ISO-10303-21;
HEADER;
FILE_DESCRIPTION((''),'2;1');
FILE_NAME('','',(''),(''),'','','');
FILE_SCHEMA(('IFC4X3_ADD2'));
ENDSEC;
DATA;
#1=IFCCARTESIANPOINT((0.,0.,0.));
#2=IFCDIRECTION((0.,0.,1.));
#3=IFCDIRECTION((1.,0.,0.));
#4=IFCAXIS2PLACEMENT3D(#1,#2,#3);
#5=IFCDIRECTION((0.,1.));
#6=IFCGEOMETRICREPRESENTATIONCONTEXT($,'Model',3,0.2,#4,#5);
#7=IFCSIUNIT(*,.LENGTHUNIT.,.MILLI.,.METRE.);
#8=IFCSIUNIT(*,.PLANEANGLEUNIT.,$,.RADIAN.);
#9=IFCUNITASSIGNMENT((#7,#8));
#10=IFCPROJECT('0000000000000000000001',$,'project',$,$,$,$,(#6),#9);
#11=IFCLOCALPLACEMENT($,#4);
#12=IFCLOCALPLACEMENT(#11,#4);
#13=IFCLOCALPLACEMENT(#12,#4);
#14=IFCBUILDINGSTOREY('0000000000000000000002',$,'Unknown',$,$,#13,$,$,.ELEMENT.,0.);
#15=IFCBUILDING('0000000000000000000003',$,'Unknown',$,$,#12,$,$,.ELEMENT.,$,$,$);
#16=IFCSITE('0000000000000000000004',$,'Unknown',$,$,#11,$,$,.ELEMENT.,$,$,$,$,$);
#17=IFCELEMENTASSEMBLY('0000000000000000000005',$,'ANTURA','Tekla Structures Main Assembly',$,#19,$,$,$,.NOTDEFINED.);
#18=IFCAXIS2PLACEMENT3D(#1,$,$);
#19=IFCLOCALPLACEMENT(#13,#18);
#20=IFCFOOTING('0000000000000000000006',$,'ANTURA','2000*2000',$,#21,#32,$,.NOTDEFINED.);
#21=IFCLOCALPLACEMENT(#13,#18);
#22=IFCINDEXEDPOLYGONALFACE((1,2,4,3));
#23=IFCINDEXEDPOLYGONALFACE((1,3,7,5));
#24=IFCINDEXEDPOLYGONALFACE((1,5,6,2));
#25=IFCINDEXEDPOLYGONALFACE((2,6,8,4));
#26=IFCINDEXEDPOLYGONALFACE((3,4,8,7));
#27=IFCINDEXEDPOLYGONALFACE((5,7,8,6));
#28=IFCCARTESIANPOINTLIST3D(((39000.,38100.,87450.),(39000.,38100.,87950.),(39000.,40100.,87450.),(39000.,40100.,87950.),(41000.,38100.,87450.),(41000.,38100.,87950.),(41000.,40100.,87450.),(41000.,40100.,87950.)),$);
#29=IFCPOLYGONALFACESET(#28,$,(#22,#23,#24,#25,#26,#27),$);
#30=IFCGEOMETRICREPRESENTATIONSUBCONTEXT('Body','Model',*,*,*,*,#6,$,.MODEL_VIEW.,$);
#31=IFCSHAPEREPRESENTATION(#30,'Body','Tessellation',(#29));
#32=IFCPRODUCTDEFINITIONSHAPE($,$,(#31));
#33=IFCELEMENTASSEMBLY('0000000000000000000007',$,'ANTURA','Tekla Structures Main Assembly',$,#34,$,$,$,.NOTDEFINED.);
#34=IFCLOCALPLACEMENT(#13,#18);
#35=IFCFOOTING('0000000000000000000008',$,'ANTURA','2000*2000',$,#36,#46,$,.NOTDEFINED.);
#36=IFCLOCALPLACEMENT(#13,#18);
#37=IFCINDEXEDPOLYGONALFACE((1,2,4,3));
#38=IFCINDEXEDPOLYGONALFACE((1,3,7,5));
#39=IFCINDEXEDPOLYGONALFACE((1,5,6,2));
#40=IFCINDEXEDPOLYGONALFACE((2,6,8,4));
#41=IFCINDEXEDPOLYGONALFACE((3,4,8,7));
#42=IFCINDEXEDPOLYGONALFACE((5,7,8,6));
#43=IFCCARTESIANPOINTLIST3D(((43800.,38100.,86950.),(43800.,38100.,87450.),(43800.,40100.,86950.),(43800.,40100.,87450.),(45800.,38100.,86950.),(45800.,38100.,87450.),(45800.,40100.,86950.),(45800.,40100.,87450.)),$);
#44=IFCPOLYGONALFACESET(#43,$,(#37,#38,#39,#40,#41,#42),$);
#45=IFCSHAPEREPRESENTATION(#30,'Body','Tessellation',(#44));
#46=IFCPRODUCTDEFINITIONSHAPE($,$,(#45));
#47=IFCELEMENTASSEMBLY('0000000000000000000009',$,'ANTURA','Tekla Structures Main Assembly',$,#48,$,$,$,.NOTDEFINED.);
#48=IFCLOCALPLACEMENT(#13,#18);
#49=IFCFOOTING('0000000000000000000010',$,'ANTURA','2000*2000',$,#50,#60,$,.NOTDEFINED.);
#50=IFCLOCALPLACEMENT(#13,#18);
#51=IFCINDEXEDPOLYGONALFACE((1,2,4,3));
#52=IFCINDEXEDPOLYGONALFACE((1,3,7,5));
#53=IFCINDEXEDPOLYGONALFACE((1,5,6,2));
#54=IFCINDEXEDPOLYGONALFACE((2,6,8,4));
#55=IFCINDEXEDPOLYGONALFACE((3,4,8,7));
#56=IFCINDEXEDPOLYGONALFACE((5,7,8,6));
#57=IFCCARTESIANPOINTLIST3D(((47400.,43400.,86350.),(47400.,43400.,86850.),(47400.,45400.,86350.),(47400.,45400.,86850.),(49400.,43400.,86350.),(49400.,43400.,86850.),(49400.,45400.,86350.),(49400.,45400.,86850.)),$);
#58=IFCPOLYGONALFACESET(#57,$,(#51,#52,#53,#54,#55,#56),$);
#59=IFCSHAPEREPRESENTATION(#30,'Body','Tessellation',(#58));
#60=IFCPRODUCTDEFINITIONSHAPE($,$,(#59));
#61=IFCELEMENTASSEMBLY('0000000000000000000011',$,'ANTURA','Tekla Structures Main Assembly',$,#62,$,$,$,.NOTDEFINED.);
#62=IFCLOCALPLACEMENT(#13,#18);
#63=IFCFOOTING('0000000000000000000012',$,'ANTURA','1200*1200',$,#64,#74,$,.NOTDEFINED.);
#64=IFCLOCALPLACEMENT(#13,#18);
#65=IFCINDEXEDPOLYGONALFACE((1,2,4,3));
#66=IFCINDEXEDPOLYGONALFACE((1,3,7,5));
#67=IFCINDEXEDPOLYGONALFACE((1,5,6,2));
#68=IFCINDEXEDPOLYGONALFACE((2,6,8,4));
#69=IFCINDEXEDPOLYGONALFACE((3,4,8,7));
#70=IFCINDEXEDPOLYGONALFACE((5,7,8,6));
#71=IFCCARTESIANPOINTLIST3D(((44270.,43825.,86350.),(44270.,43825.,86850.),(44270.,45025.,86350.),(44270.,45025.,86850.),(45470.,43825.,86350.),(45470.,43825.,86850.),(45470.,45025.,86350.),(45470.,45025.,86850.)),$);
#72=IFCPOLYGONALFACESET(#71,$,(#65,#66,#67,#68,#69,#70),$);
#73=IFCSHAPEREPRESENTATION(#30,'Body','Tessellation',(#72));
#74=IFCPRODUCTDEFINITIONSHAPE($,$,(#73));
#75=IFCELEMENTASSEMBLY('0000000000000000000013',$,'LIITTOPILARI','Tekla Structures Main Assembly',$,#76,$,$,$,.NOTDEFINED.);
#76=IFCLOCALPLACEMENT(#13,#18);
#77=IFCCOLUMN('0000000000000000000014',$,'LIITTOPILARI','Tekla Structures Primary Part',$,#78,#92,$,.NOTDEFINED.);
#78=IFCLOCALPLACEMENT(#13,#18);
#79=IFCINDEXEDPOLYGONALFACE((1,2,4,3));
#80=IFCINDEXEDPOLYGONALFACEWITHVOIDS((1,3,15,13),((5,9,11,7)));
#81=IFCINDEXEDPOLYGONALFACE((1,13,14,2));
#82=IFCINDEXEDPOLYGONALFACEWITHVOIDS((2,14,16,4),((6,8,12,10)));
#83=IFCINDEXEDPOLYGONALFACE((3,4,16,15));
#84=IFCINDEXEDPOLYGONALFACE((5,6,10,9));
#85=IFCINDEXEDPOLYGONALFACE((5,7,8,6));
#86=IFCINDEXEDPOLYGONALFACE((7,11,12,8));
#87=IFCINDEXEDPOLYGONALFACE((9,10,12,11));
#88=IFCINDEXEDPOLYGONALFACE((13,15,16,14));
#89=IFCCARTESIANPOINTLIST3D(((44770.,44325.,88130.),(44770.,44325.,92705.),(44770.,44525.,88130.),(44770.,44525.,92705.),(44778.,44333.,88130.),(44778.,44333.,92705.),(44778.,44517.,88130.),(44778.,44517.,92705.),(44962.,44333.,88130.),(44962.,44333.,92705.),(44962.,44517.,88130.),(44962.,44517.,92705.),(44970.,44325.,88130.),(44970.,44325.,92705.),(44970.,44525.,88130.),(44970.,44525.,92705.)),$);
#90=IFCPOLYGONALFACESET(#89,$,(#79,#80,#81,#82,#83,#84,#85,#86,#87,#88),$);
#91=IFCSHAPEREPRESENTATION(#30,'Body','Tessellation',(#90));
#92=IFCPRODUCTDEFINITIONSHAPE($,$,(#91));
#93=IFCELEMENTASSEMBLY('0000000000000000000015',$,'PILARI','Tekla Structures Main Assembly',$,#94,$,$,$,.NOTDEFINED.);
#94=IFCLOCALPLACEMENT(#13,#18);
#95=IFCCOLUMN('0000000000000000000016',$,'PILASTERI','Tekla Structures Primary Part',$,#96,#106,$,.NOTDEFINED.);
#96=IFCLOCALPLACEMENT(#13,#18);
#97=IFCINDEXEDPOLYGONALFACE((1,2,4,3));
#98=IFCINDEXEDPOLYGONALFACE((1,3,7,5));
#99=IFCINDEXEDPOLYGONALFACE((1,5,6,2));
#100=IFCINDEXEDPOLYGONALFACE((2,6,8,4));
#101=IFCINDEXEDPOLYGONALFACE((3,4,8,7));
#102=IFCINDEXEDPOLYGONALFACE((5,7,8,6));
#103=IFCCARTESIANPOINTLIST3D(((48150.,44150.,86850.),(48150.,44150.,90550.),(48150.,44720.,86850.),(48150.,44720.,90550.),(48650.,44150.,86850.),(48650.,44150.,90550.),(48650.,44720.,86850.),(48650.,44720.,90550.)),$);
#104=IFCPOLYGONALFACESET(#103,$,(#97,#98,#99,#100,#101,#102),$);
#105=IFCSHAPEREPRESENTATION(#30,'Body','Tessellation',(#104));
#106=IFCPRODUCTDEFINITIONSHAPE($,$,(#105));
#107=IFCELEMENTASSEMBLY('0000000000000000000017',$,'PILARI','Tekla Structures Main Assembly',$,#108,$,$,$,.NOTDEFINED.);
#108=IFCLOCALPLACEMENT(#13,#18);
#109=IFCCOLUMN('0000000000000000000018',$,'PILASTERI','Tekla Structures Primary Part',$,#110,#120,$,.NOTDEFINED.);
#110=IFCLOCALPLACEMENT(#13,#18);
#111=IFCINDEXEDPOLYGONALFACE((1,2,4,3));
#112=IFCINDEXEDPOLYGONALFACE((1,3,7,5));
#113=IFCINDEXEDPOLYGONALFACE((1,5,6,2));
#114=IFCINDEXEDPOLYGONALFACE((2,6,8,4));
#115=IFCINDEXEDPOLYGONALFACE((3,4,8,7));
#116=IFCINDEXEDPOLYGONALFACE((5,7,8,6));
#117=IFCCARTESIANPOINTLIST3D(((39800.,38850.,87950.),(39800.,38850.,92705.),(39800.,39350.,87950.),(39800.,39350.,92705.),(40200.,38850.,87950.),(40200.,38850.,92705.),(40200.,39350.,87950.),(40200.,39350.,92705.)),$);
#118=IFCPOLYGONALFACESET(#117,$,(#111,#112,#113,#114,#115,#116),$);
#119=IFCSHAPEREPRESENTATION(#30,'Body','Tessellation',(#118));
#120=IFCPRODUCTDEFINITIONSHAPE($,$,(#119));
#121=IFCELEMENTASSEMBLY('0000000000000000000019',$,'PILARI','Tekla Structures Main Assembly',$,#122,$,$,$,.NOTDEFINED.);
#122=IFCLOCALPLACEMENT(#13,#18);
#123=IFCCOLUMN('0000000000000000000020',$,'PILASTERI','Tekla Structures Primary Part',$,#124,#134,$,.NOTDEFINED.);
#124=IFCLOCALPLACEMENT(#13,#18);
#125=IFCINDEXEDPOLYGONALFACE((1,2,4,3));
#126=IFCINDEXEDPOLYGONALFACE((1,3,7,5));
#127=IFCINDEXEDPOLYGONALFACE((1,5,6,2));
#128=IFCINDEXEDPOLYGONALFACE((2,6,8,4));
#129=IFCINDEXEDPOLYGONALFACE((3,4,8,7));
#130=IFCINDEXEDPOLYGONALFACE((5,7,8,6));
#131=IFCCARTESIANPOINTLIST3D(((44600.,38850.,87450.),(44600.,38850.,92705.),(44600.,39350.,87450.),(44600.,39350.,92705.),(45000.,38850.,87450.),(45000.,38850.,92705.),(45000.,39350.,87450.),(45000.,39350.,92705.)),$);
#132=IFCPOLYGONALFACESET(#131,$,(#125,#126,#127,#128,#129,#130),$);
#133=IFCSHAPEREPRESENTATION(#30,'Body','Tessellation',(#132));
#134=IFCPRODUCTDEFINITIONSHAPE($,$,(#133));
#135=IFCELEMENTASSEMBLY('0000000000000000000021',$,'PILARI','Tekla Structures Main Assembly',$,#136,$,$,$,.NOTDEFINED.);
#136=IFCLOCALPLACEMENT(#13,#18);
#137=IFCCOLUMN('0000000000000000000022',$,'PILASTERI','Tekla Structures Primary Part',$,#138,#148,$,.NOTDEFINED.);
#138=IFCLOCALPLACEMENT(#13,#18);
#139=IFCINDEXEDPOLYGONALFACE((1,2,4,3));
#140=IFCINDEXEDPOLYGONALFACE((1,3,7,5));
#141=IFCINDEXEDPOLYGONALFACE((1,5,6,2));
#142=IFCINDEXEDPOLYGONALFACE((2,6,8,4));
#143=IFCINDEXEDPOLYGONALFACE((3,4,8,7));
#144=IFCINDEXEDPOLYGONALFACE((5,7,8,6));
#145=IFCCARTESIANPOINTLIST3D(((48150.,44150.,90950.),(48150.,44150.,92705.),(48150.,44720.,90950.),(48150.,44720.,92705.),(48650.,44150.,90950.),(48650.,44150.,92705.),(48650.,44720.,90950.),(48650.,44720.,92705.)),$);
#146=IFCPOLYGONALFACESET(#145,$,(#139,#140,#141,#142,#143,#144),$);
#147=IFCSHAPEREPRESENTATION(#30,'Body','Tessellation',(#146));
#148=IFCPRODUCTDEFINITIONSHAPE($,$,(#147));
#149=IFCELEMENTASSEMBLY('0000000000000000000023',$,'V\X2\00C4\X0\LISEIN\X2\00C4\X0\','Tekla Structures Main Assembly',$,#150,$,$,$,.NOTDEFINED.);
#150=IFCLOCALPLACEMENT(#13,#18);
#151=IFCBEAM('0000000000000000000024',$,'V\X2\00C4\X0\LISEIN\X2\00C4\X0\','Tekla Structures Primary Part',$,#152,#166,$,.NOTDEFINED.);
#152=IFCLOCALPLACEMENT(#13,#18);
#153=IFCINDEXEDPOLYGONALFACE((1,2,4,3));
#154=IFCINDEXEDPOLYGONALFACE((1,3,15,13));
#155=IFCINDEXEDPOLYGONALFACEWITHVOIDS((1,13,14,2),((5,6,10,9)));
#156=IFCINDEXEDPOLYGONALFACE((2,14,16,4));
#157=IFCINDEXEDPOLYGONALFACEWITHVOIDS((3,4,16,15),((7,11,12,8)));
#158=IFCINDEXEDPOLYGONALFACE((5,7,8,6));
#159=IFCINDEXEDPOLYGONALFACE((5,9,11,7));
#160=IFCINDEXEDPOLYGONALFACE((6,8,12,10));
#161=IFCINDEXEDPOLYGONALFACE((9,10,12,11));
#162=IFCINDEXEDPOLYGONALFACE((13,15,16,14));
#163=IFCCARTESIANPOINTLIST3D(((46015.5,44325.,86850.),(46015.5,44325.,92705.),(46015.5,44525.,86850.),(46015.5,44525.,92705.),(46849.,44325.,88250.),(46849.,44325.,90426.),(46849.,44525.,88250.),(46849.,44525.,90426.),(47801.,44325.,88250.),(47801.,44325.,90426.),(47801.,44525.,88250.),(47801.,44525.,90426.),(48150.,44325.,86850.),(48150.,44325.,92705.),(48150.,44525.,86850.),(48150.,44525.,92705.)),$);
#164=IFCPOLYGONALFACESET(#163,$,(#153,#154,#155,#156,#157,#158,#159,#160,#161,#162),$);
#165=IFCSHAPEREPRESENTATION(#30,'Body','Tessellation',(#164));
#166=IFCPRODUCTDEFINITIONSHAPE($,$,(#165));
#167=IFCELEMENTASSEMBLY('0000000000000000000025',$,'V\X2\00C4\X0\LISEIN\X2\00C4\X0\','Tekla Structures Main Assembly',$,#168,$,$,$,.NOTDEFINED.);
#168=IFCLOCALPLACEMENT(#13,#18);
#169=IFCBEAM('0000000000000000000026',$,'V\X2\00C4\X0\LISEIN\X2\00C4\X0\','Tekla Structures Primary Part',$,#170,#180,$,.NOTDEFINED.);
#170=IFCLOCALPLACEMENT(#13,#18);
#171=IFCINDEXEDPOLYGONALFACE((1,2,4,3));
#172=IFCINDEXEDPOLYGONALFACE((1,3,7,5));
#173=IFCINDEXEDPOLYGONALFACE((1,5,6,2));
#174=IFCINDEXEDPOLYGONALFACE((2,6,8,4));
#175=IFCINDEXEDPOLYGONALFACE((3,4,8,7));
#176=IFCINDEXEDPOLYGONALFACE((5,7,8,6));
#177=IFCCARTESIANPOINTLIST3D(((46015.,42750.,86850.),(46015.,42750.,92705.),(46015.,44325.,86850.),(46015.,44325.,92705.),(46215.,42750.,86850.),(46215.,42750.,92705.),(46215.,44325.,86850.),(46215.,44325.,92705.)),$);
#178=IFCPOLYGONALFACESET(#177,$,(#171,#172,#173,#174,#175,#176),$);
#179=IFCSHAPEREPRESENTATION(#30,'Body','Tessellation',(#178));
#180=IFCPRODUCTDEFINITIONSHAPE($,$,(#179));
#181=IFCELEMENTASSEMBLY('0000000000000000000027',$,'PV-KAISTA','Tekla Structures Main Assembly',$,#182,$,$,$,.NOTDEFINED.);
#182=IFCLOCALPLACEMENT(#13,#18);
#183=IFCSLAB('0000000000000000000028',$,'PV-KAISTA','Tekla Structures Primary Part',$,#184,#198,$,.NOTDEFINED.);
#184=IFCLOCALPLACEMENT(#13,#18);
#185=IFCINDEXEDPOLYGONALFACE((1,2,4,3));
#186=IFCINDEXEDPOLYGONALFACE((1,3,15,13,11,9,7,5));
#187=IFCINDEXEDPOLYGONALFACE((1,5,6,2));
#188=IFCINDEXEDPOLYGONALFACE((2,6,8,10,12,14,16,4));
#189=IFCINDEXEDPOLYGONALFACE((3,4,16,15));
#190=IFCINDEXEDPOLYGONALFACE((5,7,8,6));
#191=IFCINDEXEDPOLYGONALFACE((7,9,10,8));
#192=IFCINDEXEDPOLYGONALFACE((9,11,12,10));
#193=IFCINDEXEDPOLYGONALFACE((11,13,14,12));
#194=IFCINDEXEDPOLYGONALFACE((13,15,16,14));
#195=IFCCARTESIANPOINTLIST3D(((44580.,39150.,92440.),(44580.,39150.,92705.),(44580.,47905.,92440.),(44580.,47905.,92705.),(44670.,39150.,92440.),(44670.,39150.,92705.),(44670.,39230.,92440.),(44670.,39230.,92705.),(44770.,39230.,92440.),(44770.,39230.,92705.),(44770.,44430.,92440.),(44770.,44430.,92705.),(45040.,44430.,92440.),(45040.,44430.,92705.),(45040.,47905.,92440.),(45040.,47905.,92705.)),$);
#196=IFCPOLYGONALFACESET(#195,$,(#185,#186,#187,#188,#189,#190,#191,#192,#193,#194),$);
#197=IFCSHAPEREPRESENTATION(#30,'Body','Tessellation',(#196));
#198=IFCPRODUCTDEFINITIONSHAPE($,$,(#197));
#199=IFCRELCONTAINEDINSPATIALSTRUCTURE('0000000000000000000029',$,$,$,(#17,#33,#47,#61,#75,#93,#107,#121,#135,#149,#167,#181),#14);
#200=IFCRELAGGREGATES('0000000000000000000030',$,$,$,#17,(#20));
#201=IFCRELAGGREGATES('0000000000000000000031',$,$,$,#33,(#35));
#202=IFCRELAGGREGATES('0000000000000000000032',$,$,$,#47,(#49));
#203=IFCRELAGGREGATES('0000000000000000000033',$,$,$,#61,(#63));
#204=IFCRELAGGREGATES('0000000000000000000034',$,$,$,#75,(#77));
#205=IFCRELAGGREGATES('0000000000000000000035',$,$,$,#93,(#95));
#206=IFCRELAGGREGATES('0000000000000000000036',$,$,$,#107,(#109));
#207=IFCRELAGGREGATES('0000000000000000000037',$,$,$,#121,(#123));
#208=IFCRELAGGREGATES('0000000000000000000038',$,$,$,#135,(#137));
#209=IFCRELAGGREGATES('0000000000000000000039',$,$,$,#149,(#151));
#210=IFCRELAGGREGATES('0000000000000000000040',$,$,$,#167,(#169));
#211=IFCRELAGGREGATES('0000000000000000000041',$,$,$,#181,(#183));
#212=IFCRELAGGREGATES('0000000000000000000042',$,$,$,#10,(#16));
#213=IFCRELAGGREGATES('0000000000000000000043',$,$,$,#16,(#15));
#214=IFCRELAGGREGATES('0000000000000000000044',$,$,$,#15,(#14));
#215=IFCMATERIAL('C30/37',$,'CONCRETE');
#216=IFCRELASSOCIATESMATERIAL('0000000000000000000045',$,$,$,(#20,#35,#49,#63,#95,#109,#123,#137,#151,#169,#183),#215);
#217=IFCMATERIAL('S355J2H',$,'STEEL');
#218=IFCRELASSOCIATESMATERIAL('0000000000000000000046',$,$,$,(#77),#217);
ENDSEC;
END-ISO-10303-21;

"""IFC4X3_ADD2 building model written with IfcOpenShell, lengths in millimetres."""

from ifc_helpers import new_model, si_unit, direction, frame, origin_with_axes, place, context, subcontext, project, spatial, line, indexed_curve, outline, extrude, material, element, aggregate, save


model = new_model("IFC4X3_ADD2")

# Units and contexts
model_context = context("Model", 3, precision=0.2, world=origin_with_axes(), true_north=direction((0.0, 1.0)))
body_context = subcontext(model_context, "Body", "Model", "MODEL_VIEW")
ifc_project = project(units=[si_unit("LENGTHUNIT", "METRE", prefix="MILLI"), si_unit("PLANEANGLEUNIT", "RADIAN")], contexts=[model_context])

# Site, building, storey
site_placement = place(None, origin_with_axes())
site = spatial("IfcSite", under=ifc_project, at=site_placement, Name="Unknown", CompositionType="ELEMENT")
building_placement = place(site_placement, origin_with_axes())
building = spatial("IfcBuilding", under=site, at=building_placement, Name="Unknown", CompositionType="ELEMENT")
storey_placement = place(building_placement, origin_with_axes())
storey = spatial("IfcBuildingStorey", under=building, at=storey_placement, Name="Unknown", CompositionType="ELEMENT", Elevation=0.0)

# Element assemblies, footings
assembly_1_placement = place(storey_placement, frame((40000.0, 39100.0, 87450.0), z_axis=(-1.0, 0.0, 0.0), x_axis=(0.0, 0.0, 1.0)))
assembly_1 = element("IfcElementAssembly", 1, at=assembly_1_placement, inside=storey, Name="ANTURA", Description="Tekla Structures Main Assembly", PredefinedType="NOTDEFINED")
ifc_material_1 = material(Name="C30/37", Category="CONCRETE")
footing_1_placement = place(assembly_1_placement, origin_with_axes())
footing_1 = element("IfcFooting", 2, at=footing_1_placement, material=ifc_material_1, Name="ANTURA", Description="2000*2000", PredefinedType="NOTDEFINED", context=body_context, shape_type="SolidModel", body=[
    extrude(outline(indexed_curve([(-1000.0, -1000.0), (1000.0, -1000.0), (1000.0, 1000.0), (-1000.0, 1000.0)], segments=[line(1, 2, 3, 4, 1)])), frame((0.0, 0.0, 0.0), z_axis=(-1.0, 0.0, 0.0), x_axis=(0.0, 0.0, 1.0)), (0.0, 0.0, -1.0), 500.0),
])
aggregate(assembly_1, [footing_1])
assembly_2_placement = place(storey_placement, frame((44800.0, 39100.0, 86950.0), z_axis=(-1.0, 0.0, 0.0), x_axis=(0.0, 0.0, 1.0)))
assembly_2 = element("IfcElementAssembly", 3, at=assembly_2_placement, inside=storey, Name="ANTURA", Description="Tekla Structures Main Assembly", PredefinedType="NOTDEFINED")
footing_2_placement = place(assembly_2_placement, origin_with_axes())
footing_2 = element("IfcFooting", 4, at=footing_2_placement, material=ifc_material_1, Name="ANTURA", Description="2000*2000", PredefinedType="NOTDEFINED", context=body_context, shape_type="SolidModel", body=[
    extrude(outline(indexed_curve([(-1000.0, -1000.0), (1000.0, -1000.0), (1000.0, 1000.0), (-1000.0, 1000.0)], segments=[line(1, 2, 3, 4, 1)])), frame((0.0, 0.0, 0.0), z_axis=(-1.0, 0.0, 0.0), x_axis=(0.0, 0.0, 1.0)), (0.0, 0.0, -1.0), 500.0),
])
aggregate(assembly_2, [footing_2])
assembly_3_placement = place(storey_placement, frame((48400.0, 44400.0, 86350.0), z_axis=(-1.0, 0.0, 0.0), x_axis=(0.0, 0.0, 1.0)))
assembly_3 = element("IfcElementAssembly", 5, at=assembly_3_placement, inside=storey, Name="ANTURA", Description="Tekla Structures Main Assembly", PredefinedType="NOTDEFINED")
footing_3_placement = place(assembly_3_placement, origin_with_axes())
footing_3 = element("IfcFooting", 6, at=footing_3_placement, material=ifc_material_1, Name="ANTURA", Description="2000*2000", PredefinedType="NOTDEFINED", context=body_context, shape_type="SolidModel", body=[
    extrude(outline(indexed_curve([(-1000.0, -1000.0), (1000.0, -1000.0), (1000.0, 1000.0), (-1000.0, 1000.0)], segments=[line(1, 2, 3, 4, 1)])), frame((0.0, 0.0, 0.0), z_axis=(-1.0, 0.0, 0.0), x_axis=(0.0, 0.0, 1.0)), (0.0, 0.0, -1.0), 500.0),
])
aggregate(assembly_3, [footing_3])
assembly_4_placement = place(storey_placement, frame((44870.0, 44425.0, 86350.0), z_axis=(-1.0, 0.0, 0.0), x_axis=(0.0, 0.0, 1.0)))
assembly_4 = element("IfcElementAssembly", 7, at=assembly_4_placement, inside=storey, Name="ANTURA", Description="Tekla Structures Main Assembly", PredefinedType="NOTDEFINED")
footing_4_placement = place(assembly_4_placement, origin_with_axes())
footing_4 = element("IfcFooting", 8, at=footing_4_placement, material=ifc_material_1, Name="ANTURA", Description="1200*1200", PredefinedType="NOTDEFINED", context=body_context, shape_type="SolidModel", body=[
    extrude(outline(indexed_curve([(-600.0, -600.0), (600.0, -600.0), (600.0, 600.0), (-600.0, 600.0)], segments=[line(1, 2, 3, 4, 1)])), frame((0.0, 0.0, 0.0), z_axis=(-1.0, 0.0, 0.0), x_axis=(0.0, 0.0, 1.0)), (0.0, 0.0, -1.0), 500.0),
])
aggregate(assembly_4, [footing_4])

# Element assemblies, columns
assembly_5_placement = place(storey_placement, frame((44870.0, 44425.0, 88130.0), z_axis=(-1.0, 0.0, 0.0), x_axis=(0.0, 0.0, 1.0)))
assembly_5 = element("IfcElementAssembly", 9, at=assembly_5_placement, inside=storey, Name="LIITTOPILARI", Description="Tekla Structures Main Assembly", PredefinedType="NOTDEFINED")
ifc_material_2 = material(Name="S355J2H", Category="STEEL")
column_1_placement = place(assembly_5_placement, origin_with_axes())
column_1 = element("IfcColumn", 10, at=column_1_placement, material=ifc_material_2, Name="LIITTOPILARI", Description="Tekla Structures Primary Part", PredefinedType="NOTDEFINED", context=body_context, shape_type="SolidModel", body=[
    extrude(outline(indexed_curve([(-100.0, -100.0), (100.0, -100.0), (100.0, 100.0), (-100.0, 100.0)], segments=[line(1, 2, 3, 4, 1)]), holes=[indexed_curve([(-92.0, -92.0), (-92.0, 92.0), (92.0, 92.0), (92.0, -92.0)], segments=[line(1, 2, 3, 4, 1)])]), frame((0.0, 0.0, 0.0), z_axis=(-1.0, 0.0, 0.0), x_axis=(0.0, 0.0, 1.0)), (0.0, 0.0, -1.0), 4575.0),
])
aggregate(assembly_5, [column_1])
assembly_6_placement = place(storey_placement, frame((48400.0, 44435.0, 86850.0), z_axis=(0.0, -1.0, 0.0), x_axis=(0.0, 0.0, 1.0)))
assembly_6 = element("IfcElementAssembly", 11, at=assembly_6_placement, inside=storey, Name="PILARI", Description="Tekla Structures Main Assembly", PredefinedType="NOTDEFINED")
column_2_placement = place(assembly_6_placement, origin_with_axes())
column_2 = element("IfcColumn", 12, at=column_2_placement, material=ifc_material_1, Name="PILASTERI", Description="Tekla Structures Primary Part", PredefinedType="NOTDEFINED", context=body_context, shape_type="SolidModel", body=[
    extrude(outline(indexed_curve([(-285.0, -250.0), (285.0, -250.0), (285.0, 250.0), (-285.0, 250.0)], segments=[line(1, 2, 3, 4, 1)])), frame((0.0, 0.0, 0.0), z_axis=(-1.0, 0.0, 0.0), x_axis=(0.0, 0.0, 1.0)), (0.0, 0.0, -1.0), 3700.0),
])
aggregate(assembly_6, [column_2])
assembly_7_placement = place(storey_placement, frame((40000.0, 39100.0, 87950.0), z_axis=(0.0, -1.0, 0.0), x_axis=(0.0, 0.0, 1.0)))
assembly_7 = element("IfcElementAssembly", 13, at=assembly_7_placement, inside=storey, Name="PILARI", Description="Tekla Structures Main Assembly", PredefinedType="NOTDEFINED")
column_3_placement = place(assembly_7_placement, origin_with_axes())
column_3 = element("IfcColumn", 14, at=column_3_placement, material=ifc_material_1, Name="PILASTERI", Description="Tekla Structures Primary Part", PredefinedType="NOTDEFINED", context=body_context, shape_type="SolidModel", body=[
    extrude(outline(indexed_curve([(-250.0, -200.0), (250.0, -200.0), (250.0, 200.0), (-250.0, 200.0)], segments=[line(1, 2, 3, 4, 1)])), frame((0.0, 0.0, 0.0), z_axis=(-1.0, 0.0, 0.0), x_axis=(0.0, 0.0, 1.0)), (0.0, 0.0, -1.0), 4755.0),
])
aggregate(assembly_7, [column_3])
assembly_8_placement = place(storey_placement, frame((44800.0, 39100.0, 87450.0), z_axis=(0.0, -1.0, 0.0), x_axis=(0.0, 0.0, 1.0)))
assembly_8 = element("IfcElementAssembly", 15, at=assembly_8_placement, inside=storey, Name="PILARI", Description="Tekla Structures Main Assembly", PredefinedType="NOTDEFINED")
column_4_placement = place(assembly_8_placement, origin_with_axes())
column_4 = element("IfcColumn", 16, at=column_4_placement, material=ifc_material_1, Name="PILASTERI", Description="Tekla Structures Primary Part", PredefinedType="NOTDEFINED", context=body_context, shape_type="SolidModel", body=[
    extrude(outline(indexed_curve([(-250.0, -200.0), (250.0, -200.0), (250.0, 200.0), (-250.0, 200.0)], segments=[line(1, 2, 3, 4, 1)])), frame((0.0, 0.0, 0.0), z_axis=(-1.0, 0.0, 0.0), x_axis=(0.0, 0.0, 1.0)), (0.0, 0.0, -1.0), 5255.0),
])
aggregate(assembly_8, [column_4])
assembly_9_placement = place(storey_placement, frame((48400.0, 44435.0, 90950.0), z_axis=(0.0, -1.0, 0.0), x_axis=(0.0, 0.0, 1.0)))
assembly_9 = element("IfcElementAssembly", 17, at=assembly_9_placement, inside=storey, Name="PILARI", Description="Tekla Structures Main Assembly", PredefinedType="NOTDEFINED")
column_5_placement = place(assembly_9_placement, origin_with_axes())
column_5 = element("IfcColumn", 18, at=column_5_placement, material=ifc_material_1, Name="PILASTERI", Description="Tekla Structures Primary Part", PredefinedType="NOTDEFINED", context=body_context, shape_type="SolidModel", body=[
    extrude(outline(indexed_curve([(-285.0, -250.0), (285.0, -250.0), (285.0, 250.0), (-285.0, 250.0)], segments=[line(1, 2, 3, 4, 1)])), frame((0.0, 0.0, 0.0), z_axis=(-1.0, 0.0, 0.0), x_axis=(0.0, 0.0, 1.0)), (0.0, 0.0, -1.0), 1755.0),
])
aggregate(assembly_9, [column_5])

# Element assembly, beam, voiding feature
assembly_10_placement = place(storey_placement, frame((46015.5, 44425.0, 89777.5), z_axis=(0.0, -1.0, 0.0), x_axis=(1.0, 0.0, 0.0)))
assembly_10 = element("IfcElementAssembly", 19, at=assembly_10_placement, inside=storey, Name="VÄLISEINÄ", Description="Tekla Structures Main Assembly", PredefinedType="NOTDEFINED")
beam_1_placement = place(assembly_10_placement, origin_with_axes())
beam_1 = element("IfcBeam", 20, at=beam_1_placement, material=ifc_material_1, Name="VÄLISEINÄ", Description="Tekla Structures Primary Part", PredefinedType="NOTDEFINED", context=body_context, shape_type="SolidModel", body=[
    extrude(outline(indexed_curve([(-100.0, -2927.5), (100.0, -2927.5), (100.0, 2927.5), (-100.0, 2927.5)], segments=[line(1, 2, 3, 4, 1)])), frame((0.0, 0.0, 0.0), z_axis=(-1.0, 0.0, 0.0), x_axis=(0.0, 0.0, 1.0)), (0.0, 0.0, -1.0), 2134.5),
])
voiding_feature_placement = place(beam_1_placement, frame((833.5, -1527.5, 0.0), z_axis=(0.0, 0.0, -1.0), x_axis=(0.0, 1.0, 0.0)))
element("IfcVoidingFeature", 21, at=voiding_feature_placement, cuts=beam_1, Name="CUTPART", PredefinedType="HOLE", context=body_context, shape_type="SolidModel", body=[
    extrude(outline(indexed_curve([(0.0, 0.0), (2176.0, 0.0), (2176.0, 952.0), (0.0, 952.0)], segments=[line(1, 2, 3, 4, 1)])), frame((0.0, 0.0, 102.5), z_axis=(0.0, 0.0, 1.0), x_axis=(1.0, 0.0, 0.0)), (0.0, 0.0, -1.0), 205.0),
])
aggregate(assembly_10, [beam_1])

# Element assembly, beam
assembly_11_placement = place(storey_placement, frame((46115.0, 42750.0, 89777.5), z_axis=(1.0, 0.0, 0.0), x_axis=(0.0, 1.0, 0.0)))
assembly_11 = element("IfcElementAssembly", 22, at=assembly_11_placement, inside=storey, Name="VÄLISEINÄ", Description="Tekla Structures Main Assembly", PredefinedType="NOTDEFINED")
beam_2_placement = place(assembly_11_placement, origin_with_axes())
beam_2 = element("IfcBeam", 23, at=beam_2_placement, material=ifc_material_1, Name="VÄLISEINÄ", Description="Tekla Structures Primary Part", PredefinedType="NOTDEFINED", context=body_context, shape_type="SolidModel", body=[
    extrude(outline(indexed_curve([(-100.0, -2927.5), (100.0, -2927.5), (100.0, 2927.5), (-100.0, 2927.5)], segments=[line(1, 2, 3, 4, 1)])), frame((0.0, 0.0, 0.0), z_axis=(-1.0, 0.0, 0.0), x_axis=(0.0, 0.0, 1.0)), (0.0, 0.0, -1.0), 1575.0),
])
aggregate(assembly_11, [beam_2])

# Element assembly, slab
assembly_12_placement = place(storey_placement, frame((45040.0, 47905.0, 92572.5), z_axis=(0.0, 0.0, 1.0), x_axis=(-1.0, 0.0, 0.0)))
assembly_12 = element("IfcElementAssembly", 24, at=assembly_12_placement, inside=storey, Name="PV-KAISTA", Description="Tekla Structures Main Assembly", PredefinedType="NOTDEFINED")
slab_placement = place(assembly_12_placement, origin_with_axes())
slab = element("IfcSlab", 25, at=slab_placement, material=ifc_material_1, Name="PV-KAISTA", Description="Tekla Structures Primary Part", PredefinedType="NOTDEFINED", context=body_context, shape_type="SolidModel", body=[
    extrude(outline(indexed_curve([(0.0, 0.0), (460.0, 0.0), (460.0, 8755.0), (370.0, 8755.0), (370.0, 8675.0), (270.0, 8675.0), (270.0, 3475.0), (0.0, 3475.0)], segments=[line(1, 2, 3, 4, 5, 6, 7, 8, 1)])), frame((0.0, 0.0, 132.5), z_axis=(0.0, 0.0, 1.0), x_axis=(1.0, 0.0, 0.0)), (0.0, 0.0, -1.0), 265.0),
])
aggregate(assembly_12, [slab])

save(model, "model.ifc")
